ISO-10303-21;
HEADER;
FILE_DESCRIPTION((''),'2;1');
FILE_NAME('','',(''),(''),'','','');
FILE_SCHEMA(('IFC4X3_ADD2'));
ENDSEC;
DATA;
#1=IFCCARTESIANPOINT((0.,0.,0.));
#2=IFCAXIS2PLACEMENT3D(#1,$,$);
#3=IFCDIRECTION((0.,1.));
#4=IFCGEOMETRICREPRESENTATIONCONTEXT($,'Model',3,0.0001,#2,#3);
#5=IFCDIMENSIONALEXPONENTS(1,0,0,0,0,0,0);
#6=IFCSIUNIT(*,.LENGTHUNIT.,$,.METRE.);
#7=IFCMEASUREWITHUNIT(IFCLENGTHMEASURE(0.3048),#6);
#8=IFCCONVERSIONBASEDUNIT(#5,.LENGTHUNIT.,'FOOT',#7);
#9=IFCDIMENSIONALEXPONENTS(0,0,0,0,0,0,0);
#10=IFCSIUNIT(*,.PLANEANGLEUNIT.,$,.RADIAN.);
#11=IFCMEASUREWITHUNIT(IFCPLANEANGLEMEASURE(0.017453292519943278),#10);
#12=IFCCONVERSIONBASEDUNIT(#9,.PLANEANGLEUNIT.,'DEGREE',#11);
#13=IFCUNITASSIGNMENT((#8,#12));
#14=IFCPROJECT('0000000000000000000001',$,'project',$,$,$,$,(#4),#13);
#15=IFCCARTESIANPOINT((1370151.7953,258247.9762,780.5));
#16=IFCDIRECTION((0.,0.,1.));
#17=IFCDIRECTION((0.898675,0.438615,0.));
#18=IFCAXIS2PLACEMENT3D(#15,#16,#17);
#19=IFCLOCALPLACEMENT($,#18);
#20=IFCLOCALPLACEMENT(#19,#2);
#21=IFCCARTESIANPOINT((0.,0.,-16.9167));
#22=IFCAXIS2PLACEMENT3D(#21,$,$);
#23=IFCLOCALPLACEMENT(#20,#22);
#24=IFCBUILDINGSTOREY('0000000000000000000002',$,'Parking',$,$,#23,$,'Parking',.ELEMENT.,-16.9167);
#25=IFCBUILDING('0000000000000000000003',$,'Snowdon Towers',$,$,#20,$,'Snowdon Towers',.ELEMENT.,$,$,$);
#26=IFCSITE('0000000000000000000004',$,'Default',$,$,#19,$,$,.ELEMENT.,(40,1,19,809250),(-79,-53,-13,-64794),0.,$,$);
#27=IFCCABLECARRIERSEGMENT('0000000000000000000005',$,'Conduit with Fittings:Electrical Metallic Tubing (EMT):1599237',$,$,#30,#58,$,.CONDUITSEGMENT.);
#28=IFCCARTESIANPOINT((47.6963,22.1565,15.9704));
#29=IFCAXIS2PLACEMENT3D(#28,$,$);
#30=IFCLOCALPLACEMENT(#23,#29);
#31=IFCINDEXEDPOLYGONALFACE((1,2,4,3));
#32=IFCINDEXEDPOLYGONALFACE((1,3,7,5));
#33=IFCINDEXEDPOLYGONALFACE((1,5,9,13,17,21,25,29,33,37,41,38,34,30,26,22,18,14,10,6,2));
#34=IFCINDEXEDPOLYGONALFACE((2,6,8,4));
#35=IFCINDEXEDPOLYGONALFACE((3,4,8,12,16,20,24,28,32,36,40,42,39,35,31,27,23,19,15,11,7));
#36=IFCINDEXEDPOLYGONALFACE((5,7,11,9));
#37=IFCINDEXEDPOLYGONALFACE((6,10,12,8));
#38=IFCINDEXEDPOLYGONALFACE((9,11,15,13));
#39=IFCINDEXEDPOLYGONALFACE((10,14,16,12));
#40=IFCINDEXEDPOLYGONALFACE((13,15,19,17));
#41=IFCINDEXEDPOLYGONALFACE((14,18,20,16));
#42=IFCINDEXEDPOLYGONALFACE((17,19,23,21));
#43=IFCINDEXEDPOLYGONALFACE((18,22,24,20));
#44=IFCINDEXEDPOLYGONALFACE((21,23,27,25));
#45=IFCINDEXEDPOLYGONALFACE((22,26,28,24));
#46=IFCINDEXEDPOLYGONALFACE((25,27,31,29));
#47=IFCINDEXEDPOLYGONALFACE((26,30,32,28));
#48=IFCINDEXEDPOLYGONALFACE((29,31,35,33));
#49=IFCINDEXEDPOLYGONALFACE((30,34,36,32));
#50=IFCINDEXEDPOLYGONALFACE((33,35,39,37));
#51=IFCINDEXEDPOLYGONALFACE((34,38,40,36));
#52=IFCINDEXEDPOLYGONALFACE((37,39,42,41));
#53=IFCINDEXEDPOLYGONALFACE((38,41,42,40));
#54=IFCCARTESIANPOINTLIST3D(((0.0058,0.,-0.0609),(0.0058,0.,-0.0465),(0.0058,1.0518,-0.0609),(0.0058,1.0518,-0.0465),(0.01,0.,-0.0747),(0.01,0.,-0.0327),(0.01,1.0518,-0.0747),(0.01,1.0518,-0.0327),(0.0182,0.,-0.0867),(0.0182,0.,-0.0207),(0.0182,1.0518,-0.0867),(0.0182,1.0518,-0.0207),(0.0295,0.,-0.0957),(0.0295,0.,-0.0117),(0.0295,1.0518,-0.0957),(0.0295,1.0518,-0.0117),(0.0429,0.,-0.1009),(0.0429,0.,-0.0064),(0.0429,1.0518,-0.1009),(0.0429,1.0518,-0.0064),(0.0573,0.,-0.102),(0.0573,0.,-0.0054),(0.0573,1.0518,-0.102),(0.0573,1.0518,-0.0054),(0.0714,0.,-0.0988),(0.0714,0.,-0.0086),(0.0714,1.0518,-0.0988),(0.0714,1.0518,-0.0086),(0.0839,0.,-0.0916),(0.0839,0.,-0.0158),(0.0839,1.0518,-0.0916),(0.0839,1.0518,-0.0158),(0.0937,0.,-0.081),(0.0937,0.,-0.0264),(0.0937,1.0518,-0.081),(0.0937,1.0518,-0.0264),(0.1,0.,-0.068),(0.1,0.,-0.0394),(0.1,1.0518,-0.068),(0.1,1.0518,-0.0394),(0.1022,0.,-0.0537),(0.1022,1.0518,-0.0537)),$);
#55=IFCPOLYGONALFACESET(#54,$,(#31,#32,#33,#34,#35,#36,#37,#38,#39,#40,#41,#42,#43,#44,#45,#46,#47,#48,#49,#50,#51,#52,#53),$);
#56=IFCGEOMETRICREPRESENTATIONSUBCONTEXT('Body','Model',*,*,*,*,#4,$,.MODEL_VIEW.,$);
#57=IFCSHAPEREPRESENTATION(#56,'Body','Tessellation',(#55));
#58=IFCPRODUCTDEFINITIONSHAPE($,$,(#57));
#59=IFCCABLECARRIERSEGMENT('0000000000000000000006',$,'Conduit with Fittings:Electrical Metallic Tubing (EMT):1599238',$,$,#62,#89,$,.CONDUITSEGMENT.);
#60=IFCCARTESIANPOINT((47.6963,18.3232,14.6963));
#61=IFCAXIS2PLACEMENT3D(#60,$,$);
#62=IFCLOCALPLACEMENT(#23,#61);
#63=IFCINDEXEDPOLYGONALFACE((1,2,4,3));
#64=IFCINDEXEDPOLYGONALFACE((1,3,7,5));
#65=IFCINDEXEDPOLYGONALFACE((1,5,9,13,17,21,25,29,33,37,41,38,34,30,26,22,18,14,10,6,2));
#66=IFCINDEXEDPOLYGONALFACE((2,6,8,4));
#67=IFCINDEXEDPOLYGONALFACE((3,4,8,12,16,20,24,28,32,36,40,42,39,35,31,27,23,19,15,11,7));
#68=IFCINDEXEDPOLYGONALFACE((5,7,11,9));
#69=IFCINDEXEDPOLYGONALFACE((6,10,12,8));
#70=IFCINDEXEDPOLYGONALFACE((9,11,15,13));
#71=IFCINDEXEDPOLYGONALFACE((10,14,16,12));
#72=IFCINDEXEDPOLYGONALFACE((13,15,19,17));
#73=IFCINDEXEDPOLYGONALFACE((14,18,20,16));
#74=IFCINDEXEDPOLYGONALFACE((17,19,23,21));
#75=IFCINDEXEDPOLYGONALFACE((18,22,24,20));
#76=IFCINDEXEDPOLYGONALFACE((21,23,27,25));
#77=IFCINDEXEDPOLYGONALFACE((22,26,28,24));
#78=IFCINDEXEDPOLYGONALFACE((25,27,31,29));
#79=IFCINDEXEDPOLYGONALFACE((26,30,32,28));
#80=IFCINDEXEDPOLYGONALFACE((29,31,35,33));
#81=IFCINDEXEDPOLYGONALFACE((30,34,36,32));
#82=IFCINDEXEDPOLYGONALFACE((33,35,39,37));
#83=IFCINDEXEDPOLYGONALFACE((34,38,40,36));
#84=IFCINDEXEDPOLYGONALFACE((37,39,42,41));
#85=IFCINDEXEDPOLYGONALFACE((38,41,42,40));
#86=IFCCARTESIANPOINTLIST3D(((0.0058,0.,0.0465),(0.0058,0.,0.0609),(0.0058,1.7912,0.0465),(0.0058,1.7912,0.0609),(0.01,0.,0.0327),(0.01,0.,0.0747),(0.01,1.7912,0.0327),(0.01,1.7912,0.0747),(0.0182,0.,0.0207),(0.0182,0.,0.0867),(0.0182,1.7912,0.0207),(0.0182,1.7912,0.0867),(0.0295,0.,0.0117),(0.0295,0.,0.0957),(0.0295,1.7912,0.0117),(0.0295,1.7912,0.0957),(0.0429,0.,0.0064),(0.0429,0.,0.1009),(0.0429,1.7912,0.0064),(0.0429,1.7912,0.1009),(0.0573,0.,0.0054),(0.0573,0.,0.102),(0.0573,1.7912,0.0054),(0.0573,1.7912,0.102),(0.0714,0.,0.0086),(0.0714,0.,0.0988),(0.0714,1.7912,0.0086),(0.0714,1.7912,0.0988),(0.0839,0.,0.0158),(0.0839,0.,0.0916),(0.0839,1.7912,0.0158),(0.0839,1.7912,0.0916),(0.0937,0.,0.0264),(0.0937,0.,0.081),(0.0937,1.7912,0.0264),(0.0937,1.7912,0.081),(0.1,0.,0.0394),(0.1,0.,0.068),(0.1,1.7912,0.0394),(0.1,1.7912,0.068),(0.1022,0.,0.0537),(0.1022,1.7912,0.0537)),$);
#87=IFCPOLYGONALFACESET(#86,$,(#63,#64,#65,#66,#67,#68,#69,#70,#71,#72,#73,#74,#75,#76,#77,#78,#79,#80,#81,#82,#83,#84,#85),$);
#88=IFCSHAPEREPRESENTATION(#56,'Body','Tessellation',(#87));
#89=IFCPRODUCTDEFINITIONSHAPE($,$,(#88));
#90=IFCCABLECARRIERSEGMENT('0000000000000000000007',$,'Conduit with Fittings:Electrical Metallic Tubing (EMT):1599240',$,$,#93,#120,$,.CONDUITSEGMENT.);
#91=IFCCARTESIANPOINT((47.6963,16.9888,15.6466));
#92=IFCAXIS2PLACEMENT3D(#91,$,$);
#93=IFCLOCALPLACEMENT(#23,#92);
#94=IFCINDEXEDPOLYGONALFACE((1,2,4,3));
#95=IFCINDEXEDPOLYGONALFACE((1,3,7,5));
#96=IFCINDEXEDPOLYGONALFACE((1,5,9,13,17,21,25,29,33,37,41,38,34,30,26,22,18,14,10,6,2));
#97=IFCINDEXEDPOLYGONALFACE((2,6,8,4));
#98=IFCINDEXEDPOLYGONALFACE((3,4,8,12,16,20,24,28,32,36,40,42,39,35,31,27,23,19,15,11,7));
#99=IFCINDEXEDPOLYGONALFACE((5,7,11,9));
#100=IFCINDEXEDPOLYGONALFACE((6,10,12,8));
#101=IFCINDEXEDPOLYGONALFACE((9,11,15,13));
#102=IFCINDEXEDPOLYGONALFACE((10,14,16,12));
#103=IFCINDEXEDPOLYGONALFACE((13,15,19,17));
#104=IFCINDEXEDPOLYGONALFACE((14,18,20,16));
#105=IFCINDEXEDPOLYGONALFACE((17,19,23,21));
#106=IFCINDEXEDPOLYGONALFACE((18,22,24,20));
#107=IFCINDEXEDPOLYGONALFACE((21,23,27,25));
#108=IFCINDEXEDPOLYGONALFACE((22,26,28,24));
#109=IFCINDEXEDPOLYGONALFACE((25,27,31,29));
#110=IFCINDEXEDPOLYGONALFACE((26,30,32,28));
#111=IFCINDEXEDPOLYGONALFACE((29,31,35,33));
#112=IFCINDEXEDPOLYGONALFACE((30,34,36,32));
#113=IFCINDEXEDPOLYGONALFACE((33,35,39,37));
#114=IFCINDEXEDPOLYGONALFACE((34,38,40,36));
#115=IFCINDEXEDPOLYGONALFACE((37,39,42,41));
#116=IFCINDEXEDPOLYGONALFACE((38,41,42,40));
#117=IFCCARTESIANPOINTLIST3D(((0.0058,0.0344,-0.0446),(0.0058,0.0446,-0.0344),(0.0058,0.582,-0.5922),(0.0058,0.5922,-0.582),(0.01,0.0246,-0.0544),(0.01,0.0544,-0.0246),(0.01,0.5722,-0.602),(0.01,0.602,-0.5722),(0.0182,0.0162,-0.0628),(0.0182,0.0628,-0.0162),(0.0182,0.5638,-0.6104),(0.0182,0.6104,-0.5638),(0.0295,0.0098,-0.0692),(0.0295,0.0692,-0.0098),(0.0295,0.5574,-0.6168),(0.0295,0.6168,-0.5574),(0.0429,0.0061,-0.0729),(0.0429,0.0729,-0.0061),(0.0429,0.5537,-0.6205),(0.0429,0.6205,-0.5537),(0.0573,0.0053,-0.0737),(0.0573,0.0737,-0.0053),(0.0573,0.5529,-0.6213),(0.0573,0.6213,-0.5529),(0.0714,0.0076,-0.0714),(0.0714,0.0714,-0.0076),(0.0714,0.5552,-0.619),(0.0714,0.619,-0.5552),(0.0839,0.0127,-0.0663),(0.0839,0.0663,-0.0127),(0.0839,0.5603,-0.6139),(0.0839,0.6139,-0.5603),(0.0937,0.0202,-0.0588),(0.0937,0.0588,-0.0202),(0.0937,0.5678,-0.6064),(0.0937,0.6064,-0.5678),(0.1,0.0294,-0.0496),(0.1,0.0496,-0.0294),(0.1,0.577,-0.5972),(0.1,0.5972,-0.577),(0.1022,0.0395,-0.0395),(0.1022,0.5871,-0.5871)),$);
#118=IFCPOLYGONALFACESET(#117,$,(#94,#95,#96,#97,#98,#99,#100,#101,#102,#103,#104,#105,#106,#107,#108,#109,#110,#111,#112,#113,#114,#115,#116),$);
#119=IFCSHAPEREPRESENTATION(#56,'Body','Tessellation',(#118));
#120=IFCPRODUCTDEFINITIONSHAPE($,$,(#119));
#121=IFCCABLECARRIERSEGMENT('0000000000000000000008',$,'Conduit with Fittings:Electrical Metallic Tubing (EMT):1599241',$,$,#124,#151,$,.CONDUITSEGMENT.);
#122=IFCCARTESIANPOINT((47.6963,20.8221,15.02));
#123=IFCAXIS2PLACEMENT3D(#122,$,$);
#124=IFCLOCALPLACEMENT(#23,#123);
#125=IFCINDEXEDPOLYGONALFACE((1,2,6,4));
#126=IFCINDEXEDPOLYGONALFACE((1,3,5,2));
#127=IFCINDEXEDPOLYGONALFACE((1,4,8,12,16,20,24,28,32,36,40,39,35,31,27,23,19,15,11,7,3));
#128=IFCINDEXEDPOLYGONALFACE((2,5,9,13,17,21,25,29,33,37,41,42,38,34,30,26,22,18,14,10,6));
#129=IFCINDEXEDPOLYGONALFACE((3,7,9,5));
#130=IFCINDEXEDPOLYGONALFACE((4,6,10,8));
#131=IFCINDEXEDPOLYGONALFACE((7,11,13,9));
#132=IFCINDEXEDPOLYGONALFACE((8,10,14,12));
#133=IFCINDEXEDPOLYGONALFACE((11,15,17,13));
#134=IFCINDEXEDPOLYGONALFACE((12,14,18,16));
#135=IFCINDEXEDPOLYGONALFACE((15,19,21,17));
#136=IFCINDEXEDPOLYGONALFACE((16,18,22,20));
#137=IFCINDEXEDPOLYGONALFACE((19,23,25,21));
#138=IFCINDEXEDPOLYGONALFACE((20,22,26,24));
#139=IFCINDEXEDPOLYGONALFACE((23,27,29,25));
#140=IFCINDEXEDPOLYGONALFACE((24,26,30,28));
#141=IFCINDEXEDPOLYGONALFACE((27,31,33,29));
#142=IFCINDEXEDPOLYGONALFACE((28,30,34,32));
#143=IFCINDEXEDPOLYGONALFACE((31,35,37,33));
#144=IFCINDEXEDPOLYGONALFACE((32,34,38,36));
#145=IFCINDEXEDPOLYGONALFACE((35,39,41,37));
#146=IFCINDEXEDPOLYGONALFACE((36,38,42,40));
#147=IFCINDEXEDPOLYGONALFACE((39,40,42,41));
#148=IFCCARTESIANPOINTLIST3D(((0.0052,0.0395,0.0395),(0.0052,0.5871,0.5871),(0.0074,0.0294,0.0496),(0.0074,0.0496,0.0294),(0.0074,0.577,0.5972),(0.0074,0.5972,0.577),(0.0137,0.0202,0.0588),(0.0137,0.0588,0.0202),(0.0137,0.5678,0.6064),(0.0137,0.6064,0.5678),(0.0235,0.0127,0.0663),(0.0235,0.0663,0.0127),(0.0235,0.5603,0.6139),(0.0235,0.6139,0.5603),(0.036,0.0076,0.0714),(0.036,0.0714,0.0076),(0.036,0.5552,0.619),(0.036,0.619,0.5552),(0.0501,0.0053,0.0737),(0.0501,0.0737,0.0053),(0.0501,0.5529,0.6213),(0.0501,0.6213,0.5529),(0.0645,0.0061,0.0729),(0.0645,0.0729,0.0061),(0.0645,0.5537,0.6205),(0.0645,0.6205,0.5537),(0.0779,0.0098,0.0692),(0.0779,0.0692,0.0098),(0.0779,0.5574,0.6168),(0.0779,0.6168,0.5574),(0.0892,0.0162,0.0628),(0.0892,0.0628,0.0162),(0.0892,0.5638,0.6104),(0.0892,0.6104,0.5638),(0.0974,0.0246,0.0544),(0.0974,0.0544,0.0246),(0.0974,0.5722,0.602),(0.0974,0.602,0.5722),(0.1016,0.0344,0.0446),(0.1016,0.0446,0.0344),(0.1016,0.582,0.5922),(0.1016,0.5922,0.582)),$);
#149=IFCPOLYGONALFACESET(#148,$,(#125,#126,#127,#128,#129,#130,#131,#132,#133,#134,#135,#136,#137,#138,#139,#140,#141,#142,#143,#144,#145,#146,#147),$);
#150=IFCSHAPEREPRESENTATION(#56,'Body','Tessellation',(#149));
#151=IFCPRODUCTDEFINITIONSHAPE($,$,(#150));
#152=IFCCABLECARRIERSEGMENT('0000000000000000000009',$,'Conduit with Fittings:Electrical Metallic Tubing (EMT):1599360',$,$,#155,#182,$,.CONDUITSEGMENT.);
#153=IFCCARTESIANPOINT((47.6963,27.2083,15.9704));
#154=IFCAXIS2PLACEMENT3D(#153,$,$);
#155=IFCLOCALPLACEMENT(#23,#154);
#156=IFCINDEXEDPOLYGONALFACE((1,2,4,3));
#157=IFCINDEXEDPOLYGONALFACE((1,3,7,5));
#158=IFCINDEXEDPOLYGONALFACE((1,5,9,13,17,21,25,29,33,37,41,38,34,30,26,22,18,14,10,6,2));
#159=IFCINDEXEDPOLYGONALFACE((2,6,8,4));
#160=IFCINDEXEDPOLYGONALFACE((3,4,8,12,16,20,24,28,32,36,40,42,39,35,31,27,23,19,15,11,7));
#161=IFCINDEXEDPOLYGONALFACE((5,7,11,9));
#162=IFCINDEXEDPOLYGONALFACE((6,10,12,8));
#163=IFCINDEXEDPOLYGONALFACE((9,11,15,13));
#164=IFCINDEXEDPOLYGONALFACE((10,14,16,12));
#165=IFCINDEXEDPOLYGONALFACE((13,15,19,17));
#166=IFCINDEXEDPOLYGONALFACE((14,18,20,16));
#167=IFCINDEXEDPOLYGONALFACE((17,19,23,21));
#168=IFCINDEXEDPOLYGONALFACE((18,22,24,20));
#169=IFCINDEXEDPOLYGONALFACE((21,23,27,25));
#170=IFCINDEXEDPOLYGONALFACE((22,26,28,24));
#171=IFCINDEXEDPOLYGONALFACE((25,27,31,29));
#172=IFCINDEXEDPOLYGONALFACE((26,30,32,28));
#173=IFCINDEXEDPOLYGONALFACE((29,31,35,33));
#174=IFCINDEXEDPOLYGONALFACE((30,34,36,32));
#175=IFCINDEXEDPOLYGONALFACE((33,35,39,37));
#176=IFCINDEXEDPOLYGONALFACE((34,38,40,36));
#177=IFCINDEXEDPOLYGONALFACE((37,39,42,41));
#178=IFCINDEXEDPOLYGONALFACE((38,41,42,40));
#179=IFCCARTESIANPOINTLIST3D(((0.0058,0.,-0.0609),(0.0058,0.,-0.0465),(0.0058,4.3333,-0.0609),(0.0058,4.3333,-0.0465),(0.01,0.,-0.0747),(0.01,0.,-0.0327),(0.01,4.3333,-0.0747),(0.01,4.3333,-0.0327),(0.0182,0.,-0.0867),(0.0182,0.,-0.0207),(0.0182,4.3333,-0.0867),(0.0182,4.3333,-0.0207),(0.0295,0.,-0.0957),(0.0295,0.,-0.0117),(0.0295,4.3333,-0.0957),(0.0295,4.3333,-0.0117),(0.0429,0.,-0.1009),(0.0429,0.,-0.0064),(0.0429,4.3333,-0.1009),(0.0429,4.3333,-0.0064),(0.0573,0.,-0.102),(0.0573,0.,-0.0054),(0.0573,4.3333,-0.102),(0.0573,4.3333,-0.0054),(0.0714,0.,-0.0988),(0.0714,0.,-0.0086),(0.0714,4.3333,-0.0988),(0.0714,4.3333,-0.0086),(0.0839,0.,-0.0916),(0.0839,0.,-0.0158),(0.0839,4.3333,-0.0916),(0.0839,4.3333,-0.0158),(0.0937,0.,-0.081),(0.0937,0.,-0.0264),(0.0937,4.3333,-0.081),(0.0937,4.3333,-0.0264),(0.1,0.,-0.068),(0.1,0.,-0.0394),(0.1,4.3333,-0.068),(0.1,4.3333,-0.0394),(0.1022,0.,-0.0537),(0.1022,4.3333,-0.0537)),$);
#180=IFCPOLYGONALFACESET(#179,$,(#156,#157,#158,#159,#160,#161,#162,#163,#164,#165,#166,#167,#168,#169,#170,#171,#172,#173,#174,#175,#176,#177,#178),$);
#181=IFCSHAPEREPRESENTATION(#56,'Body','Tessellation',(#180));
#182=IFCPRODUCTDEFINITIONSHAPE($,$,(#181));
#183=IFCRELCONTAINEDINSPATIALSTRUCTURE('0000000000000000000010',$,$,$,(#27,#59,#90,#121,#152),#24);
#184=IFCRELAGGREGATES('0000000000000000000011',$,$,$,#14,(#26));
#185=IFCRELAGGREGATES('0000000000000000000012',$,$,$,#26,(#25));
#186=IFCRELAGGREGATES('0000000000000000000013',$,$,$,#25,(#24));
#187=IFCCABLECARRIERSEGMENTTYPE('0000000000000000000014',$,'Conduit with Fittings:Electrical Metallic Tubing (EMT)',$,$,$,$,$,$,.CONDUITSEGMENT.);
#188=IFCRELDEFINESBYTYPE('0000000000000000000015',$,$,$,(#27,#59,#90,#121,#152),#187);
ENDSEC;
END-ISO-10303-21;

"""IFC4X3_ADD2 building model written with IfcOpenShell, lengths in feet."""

from ifc_helpers import new_model, entity, si_unit, converted_unit, direction, frame, frame_2d, origin, origin_2d_with_axis, place, context, subcontext, project, spatial, circle, extrude, type_object, element, save


model = new_model("IFC4X3_ADD2")

# Units and contexts
model_context = context("Model", 3, precision=0.0001, world=origin(), true_north=direction((0.0, 1.0)))
body_context = subcontext(model_context, "Body", "Model", "MODEL_VIEW")
ifc_project = project(units=[converted_unit("LENGTHUNIT", "FOOT", entity("IfcLengthMeasure", 0.3048), si_unit("LENGTHUNIT", "METRE"), dimensions=[1, 0, 0, 0, 0, 0, 0]), converted_unit("PLANEANGLEUNIT", "DEGREE", entity("IfcPlaneAngleMeasure", 0.017453292519943278), si_unit("PLANEANGLEUNIT", "RADIAN"), dimensions=[0, 0, 0, 0, 0, 0, 0])], contexts=[model_context])

# Site, building, storey
site_placement = place(None, frame((1370151.7953, 258247.9762, 780.5), z_axis=(0.0, 0.0, 1.0), x_axis=(0.898675, 0.438615, 0.0)))
site = spatial("IfcSite", under=ifc_project, at=site_placement, Name="Default", CompositionType="ELEMENT", RefLatitude=(40, 1, 19, 809250), RefLongitude=(-79, -53, -13, -64794), RefElevation=0.0)
building_placement = place(site_placement, origin())
building = spatial("IfcBuilding", under=site, at=building_placement, Name="Snowdon Towers", LongName="Snowdon Towers", CompositionType="ELEMENT")
storey_placement = place(building_placement, frame((0.0, 0.0, -16.9167)))
storey = spatial("IfcBuildingStorey", under=building, at=storey_placement, Name="Parking", LongName="Parking", CompositionType="ELEMENT", Elevation=-16.9167)

# Cable carrier segments
cable_carrier_segment_type_1 = type_object("IfcCableCarrierSegmentType", Name="Conduit with Fittings:Electrical Metallic Tubing (EMT)", PredefinedType="CONDUITSEGMENT")
cable_carrier_segment_1_placement = place(storey_placement, frame((47.6963, 22.1565, 15.9704)))
element("IfcCableCarrierSegment", 1, at=cable_carrier_segment_1_placement, inside=storey, type_object=cable_carrier_segment_type_1, Name="Conduit with Fittings:Electrical Metallic Tubing (EMT):1599237", PredefinedType="CONDUITSEGMENT", context=body_context, shape_type="SweptSolid", body=[
    extrude(circle(Radius=0.0485, at=frame_2d((0.0, 0.0), x_axis=(1.0, 0.0))), frame((0.0537, 0.0, -0.0537), z_axis=(0.0, 1.0, 0.0), x_axis=(1.0, 0.0, 0.0)), (0.0, 0.0, 1.0), 1.0518),
])
cable_carrier_segment_2_placement = place(storey_placement, frame((47.6963, 18.3232, 14.6963)))
element("IfcCableCarrierSegment", 2, at=cable_carrier_segment_2_placement, inside=storey, type_object=cable_carrier_segment_type_1, Name="Conduit with Fittings:Electrical Metallic Tubing (EMT):1599238", PredefinedType="CONDUITSEGMENT", context=body_context, shape_type="SweptSolid", body=[
    extrude(circle(Radius=0.0485, at=origin_2d_with_axis()), frame((0.0537, 0.0, 0.0537), z_axis=(0.0, 1.0, 0.0), x_axis=(1.0, 0.0, 0.0)), (0.0, 0.0, 1.0), 1.7912),
])
cable_carrier_segment_3_placement = place(storey_placement, frame((47.6963, 16.9888, 15.6466)))
element("IfcCableCarrierSegment", 3, at=cable_carrier_segment_3_placement, inside=storey, type_object=cable_carrier_segment_type_1, Name="Conduit with Fittings:Electrical Metallic Tubing (EMT):1599240", PredefinedType="CONDUITSEGMENT", context=body_context, shape_type="SweptSolid", body=[
    extrude(circle(Radius=0.0485, at=frame_2d((0.0, 0.0), x_axis=(1.0, 0.0))), frame((0.0537, 0.0395, -0.0395), z_axis=(0.0, 0.707107, -0.707107), x_axis=(1.0, 0.0, 0.0)), (0.0, 0.0, 1.0), 0.7744),
])
cable_carrier_segment_4_placement = place(storey_placement, frame((47.6963, 20.8221, 15.02)))
element("IfcCableCarrierSegment", 4, at=cable_carrier_segment_4_placement, inside=storey, type_object=cable_carrier_segment_type_1, Name="Conduit with Fittings:Electrical Metallic Tubing (EMT):1599241", PredefinedType="CONDUITSEGMENT", context=body_context, shape_type="SweptSolid", body=[
    extrude(circle(Radius=0.0485, at=frame_2d((0.0, 0.0), x_axis=(1.0, 0.0))), frame((0.0537, 0.0395, 0.0395), z_axis=(0.0, 0.707107, 0.707107), x_axis=(-1.0, 0.0, 0.0)), (0.0, 0.0, 1.0), 0.7744),
])
cable_carrier_segment_5_placement = place(storey_placement, frame((47.6963, 27.2083, 15.9704)))
element("IfcCableCarrierSegment", 5, at=cable_carrier_segment_5_placement, inside=storey, type_object=cable_carrier_segment_type_1, Name="Conduit with Fittings:Electrical Metallic Tubing (EMT):1599360", PredefinedType="CONDUITSEGMENT", context=body_context, shape_type="SweptSolid", body=[
    extrude(circle(Radius=0.0485, at=origin_2d_with_axis()), frame((0.0537, 0.0, -0.0537), z_axis=(0.0, 1.0, 0.0), x_axis=(1.0, 0.0, 0.0)), (0.0, 0.0, 1.0), 4.3333),
])

save(model, "model.ifc")
